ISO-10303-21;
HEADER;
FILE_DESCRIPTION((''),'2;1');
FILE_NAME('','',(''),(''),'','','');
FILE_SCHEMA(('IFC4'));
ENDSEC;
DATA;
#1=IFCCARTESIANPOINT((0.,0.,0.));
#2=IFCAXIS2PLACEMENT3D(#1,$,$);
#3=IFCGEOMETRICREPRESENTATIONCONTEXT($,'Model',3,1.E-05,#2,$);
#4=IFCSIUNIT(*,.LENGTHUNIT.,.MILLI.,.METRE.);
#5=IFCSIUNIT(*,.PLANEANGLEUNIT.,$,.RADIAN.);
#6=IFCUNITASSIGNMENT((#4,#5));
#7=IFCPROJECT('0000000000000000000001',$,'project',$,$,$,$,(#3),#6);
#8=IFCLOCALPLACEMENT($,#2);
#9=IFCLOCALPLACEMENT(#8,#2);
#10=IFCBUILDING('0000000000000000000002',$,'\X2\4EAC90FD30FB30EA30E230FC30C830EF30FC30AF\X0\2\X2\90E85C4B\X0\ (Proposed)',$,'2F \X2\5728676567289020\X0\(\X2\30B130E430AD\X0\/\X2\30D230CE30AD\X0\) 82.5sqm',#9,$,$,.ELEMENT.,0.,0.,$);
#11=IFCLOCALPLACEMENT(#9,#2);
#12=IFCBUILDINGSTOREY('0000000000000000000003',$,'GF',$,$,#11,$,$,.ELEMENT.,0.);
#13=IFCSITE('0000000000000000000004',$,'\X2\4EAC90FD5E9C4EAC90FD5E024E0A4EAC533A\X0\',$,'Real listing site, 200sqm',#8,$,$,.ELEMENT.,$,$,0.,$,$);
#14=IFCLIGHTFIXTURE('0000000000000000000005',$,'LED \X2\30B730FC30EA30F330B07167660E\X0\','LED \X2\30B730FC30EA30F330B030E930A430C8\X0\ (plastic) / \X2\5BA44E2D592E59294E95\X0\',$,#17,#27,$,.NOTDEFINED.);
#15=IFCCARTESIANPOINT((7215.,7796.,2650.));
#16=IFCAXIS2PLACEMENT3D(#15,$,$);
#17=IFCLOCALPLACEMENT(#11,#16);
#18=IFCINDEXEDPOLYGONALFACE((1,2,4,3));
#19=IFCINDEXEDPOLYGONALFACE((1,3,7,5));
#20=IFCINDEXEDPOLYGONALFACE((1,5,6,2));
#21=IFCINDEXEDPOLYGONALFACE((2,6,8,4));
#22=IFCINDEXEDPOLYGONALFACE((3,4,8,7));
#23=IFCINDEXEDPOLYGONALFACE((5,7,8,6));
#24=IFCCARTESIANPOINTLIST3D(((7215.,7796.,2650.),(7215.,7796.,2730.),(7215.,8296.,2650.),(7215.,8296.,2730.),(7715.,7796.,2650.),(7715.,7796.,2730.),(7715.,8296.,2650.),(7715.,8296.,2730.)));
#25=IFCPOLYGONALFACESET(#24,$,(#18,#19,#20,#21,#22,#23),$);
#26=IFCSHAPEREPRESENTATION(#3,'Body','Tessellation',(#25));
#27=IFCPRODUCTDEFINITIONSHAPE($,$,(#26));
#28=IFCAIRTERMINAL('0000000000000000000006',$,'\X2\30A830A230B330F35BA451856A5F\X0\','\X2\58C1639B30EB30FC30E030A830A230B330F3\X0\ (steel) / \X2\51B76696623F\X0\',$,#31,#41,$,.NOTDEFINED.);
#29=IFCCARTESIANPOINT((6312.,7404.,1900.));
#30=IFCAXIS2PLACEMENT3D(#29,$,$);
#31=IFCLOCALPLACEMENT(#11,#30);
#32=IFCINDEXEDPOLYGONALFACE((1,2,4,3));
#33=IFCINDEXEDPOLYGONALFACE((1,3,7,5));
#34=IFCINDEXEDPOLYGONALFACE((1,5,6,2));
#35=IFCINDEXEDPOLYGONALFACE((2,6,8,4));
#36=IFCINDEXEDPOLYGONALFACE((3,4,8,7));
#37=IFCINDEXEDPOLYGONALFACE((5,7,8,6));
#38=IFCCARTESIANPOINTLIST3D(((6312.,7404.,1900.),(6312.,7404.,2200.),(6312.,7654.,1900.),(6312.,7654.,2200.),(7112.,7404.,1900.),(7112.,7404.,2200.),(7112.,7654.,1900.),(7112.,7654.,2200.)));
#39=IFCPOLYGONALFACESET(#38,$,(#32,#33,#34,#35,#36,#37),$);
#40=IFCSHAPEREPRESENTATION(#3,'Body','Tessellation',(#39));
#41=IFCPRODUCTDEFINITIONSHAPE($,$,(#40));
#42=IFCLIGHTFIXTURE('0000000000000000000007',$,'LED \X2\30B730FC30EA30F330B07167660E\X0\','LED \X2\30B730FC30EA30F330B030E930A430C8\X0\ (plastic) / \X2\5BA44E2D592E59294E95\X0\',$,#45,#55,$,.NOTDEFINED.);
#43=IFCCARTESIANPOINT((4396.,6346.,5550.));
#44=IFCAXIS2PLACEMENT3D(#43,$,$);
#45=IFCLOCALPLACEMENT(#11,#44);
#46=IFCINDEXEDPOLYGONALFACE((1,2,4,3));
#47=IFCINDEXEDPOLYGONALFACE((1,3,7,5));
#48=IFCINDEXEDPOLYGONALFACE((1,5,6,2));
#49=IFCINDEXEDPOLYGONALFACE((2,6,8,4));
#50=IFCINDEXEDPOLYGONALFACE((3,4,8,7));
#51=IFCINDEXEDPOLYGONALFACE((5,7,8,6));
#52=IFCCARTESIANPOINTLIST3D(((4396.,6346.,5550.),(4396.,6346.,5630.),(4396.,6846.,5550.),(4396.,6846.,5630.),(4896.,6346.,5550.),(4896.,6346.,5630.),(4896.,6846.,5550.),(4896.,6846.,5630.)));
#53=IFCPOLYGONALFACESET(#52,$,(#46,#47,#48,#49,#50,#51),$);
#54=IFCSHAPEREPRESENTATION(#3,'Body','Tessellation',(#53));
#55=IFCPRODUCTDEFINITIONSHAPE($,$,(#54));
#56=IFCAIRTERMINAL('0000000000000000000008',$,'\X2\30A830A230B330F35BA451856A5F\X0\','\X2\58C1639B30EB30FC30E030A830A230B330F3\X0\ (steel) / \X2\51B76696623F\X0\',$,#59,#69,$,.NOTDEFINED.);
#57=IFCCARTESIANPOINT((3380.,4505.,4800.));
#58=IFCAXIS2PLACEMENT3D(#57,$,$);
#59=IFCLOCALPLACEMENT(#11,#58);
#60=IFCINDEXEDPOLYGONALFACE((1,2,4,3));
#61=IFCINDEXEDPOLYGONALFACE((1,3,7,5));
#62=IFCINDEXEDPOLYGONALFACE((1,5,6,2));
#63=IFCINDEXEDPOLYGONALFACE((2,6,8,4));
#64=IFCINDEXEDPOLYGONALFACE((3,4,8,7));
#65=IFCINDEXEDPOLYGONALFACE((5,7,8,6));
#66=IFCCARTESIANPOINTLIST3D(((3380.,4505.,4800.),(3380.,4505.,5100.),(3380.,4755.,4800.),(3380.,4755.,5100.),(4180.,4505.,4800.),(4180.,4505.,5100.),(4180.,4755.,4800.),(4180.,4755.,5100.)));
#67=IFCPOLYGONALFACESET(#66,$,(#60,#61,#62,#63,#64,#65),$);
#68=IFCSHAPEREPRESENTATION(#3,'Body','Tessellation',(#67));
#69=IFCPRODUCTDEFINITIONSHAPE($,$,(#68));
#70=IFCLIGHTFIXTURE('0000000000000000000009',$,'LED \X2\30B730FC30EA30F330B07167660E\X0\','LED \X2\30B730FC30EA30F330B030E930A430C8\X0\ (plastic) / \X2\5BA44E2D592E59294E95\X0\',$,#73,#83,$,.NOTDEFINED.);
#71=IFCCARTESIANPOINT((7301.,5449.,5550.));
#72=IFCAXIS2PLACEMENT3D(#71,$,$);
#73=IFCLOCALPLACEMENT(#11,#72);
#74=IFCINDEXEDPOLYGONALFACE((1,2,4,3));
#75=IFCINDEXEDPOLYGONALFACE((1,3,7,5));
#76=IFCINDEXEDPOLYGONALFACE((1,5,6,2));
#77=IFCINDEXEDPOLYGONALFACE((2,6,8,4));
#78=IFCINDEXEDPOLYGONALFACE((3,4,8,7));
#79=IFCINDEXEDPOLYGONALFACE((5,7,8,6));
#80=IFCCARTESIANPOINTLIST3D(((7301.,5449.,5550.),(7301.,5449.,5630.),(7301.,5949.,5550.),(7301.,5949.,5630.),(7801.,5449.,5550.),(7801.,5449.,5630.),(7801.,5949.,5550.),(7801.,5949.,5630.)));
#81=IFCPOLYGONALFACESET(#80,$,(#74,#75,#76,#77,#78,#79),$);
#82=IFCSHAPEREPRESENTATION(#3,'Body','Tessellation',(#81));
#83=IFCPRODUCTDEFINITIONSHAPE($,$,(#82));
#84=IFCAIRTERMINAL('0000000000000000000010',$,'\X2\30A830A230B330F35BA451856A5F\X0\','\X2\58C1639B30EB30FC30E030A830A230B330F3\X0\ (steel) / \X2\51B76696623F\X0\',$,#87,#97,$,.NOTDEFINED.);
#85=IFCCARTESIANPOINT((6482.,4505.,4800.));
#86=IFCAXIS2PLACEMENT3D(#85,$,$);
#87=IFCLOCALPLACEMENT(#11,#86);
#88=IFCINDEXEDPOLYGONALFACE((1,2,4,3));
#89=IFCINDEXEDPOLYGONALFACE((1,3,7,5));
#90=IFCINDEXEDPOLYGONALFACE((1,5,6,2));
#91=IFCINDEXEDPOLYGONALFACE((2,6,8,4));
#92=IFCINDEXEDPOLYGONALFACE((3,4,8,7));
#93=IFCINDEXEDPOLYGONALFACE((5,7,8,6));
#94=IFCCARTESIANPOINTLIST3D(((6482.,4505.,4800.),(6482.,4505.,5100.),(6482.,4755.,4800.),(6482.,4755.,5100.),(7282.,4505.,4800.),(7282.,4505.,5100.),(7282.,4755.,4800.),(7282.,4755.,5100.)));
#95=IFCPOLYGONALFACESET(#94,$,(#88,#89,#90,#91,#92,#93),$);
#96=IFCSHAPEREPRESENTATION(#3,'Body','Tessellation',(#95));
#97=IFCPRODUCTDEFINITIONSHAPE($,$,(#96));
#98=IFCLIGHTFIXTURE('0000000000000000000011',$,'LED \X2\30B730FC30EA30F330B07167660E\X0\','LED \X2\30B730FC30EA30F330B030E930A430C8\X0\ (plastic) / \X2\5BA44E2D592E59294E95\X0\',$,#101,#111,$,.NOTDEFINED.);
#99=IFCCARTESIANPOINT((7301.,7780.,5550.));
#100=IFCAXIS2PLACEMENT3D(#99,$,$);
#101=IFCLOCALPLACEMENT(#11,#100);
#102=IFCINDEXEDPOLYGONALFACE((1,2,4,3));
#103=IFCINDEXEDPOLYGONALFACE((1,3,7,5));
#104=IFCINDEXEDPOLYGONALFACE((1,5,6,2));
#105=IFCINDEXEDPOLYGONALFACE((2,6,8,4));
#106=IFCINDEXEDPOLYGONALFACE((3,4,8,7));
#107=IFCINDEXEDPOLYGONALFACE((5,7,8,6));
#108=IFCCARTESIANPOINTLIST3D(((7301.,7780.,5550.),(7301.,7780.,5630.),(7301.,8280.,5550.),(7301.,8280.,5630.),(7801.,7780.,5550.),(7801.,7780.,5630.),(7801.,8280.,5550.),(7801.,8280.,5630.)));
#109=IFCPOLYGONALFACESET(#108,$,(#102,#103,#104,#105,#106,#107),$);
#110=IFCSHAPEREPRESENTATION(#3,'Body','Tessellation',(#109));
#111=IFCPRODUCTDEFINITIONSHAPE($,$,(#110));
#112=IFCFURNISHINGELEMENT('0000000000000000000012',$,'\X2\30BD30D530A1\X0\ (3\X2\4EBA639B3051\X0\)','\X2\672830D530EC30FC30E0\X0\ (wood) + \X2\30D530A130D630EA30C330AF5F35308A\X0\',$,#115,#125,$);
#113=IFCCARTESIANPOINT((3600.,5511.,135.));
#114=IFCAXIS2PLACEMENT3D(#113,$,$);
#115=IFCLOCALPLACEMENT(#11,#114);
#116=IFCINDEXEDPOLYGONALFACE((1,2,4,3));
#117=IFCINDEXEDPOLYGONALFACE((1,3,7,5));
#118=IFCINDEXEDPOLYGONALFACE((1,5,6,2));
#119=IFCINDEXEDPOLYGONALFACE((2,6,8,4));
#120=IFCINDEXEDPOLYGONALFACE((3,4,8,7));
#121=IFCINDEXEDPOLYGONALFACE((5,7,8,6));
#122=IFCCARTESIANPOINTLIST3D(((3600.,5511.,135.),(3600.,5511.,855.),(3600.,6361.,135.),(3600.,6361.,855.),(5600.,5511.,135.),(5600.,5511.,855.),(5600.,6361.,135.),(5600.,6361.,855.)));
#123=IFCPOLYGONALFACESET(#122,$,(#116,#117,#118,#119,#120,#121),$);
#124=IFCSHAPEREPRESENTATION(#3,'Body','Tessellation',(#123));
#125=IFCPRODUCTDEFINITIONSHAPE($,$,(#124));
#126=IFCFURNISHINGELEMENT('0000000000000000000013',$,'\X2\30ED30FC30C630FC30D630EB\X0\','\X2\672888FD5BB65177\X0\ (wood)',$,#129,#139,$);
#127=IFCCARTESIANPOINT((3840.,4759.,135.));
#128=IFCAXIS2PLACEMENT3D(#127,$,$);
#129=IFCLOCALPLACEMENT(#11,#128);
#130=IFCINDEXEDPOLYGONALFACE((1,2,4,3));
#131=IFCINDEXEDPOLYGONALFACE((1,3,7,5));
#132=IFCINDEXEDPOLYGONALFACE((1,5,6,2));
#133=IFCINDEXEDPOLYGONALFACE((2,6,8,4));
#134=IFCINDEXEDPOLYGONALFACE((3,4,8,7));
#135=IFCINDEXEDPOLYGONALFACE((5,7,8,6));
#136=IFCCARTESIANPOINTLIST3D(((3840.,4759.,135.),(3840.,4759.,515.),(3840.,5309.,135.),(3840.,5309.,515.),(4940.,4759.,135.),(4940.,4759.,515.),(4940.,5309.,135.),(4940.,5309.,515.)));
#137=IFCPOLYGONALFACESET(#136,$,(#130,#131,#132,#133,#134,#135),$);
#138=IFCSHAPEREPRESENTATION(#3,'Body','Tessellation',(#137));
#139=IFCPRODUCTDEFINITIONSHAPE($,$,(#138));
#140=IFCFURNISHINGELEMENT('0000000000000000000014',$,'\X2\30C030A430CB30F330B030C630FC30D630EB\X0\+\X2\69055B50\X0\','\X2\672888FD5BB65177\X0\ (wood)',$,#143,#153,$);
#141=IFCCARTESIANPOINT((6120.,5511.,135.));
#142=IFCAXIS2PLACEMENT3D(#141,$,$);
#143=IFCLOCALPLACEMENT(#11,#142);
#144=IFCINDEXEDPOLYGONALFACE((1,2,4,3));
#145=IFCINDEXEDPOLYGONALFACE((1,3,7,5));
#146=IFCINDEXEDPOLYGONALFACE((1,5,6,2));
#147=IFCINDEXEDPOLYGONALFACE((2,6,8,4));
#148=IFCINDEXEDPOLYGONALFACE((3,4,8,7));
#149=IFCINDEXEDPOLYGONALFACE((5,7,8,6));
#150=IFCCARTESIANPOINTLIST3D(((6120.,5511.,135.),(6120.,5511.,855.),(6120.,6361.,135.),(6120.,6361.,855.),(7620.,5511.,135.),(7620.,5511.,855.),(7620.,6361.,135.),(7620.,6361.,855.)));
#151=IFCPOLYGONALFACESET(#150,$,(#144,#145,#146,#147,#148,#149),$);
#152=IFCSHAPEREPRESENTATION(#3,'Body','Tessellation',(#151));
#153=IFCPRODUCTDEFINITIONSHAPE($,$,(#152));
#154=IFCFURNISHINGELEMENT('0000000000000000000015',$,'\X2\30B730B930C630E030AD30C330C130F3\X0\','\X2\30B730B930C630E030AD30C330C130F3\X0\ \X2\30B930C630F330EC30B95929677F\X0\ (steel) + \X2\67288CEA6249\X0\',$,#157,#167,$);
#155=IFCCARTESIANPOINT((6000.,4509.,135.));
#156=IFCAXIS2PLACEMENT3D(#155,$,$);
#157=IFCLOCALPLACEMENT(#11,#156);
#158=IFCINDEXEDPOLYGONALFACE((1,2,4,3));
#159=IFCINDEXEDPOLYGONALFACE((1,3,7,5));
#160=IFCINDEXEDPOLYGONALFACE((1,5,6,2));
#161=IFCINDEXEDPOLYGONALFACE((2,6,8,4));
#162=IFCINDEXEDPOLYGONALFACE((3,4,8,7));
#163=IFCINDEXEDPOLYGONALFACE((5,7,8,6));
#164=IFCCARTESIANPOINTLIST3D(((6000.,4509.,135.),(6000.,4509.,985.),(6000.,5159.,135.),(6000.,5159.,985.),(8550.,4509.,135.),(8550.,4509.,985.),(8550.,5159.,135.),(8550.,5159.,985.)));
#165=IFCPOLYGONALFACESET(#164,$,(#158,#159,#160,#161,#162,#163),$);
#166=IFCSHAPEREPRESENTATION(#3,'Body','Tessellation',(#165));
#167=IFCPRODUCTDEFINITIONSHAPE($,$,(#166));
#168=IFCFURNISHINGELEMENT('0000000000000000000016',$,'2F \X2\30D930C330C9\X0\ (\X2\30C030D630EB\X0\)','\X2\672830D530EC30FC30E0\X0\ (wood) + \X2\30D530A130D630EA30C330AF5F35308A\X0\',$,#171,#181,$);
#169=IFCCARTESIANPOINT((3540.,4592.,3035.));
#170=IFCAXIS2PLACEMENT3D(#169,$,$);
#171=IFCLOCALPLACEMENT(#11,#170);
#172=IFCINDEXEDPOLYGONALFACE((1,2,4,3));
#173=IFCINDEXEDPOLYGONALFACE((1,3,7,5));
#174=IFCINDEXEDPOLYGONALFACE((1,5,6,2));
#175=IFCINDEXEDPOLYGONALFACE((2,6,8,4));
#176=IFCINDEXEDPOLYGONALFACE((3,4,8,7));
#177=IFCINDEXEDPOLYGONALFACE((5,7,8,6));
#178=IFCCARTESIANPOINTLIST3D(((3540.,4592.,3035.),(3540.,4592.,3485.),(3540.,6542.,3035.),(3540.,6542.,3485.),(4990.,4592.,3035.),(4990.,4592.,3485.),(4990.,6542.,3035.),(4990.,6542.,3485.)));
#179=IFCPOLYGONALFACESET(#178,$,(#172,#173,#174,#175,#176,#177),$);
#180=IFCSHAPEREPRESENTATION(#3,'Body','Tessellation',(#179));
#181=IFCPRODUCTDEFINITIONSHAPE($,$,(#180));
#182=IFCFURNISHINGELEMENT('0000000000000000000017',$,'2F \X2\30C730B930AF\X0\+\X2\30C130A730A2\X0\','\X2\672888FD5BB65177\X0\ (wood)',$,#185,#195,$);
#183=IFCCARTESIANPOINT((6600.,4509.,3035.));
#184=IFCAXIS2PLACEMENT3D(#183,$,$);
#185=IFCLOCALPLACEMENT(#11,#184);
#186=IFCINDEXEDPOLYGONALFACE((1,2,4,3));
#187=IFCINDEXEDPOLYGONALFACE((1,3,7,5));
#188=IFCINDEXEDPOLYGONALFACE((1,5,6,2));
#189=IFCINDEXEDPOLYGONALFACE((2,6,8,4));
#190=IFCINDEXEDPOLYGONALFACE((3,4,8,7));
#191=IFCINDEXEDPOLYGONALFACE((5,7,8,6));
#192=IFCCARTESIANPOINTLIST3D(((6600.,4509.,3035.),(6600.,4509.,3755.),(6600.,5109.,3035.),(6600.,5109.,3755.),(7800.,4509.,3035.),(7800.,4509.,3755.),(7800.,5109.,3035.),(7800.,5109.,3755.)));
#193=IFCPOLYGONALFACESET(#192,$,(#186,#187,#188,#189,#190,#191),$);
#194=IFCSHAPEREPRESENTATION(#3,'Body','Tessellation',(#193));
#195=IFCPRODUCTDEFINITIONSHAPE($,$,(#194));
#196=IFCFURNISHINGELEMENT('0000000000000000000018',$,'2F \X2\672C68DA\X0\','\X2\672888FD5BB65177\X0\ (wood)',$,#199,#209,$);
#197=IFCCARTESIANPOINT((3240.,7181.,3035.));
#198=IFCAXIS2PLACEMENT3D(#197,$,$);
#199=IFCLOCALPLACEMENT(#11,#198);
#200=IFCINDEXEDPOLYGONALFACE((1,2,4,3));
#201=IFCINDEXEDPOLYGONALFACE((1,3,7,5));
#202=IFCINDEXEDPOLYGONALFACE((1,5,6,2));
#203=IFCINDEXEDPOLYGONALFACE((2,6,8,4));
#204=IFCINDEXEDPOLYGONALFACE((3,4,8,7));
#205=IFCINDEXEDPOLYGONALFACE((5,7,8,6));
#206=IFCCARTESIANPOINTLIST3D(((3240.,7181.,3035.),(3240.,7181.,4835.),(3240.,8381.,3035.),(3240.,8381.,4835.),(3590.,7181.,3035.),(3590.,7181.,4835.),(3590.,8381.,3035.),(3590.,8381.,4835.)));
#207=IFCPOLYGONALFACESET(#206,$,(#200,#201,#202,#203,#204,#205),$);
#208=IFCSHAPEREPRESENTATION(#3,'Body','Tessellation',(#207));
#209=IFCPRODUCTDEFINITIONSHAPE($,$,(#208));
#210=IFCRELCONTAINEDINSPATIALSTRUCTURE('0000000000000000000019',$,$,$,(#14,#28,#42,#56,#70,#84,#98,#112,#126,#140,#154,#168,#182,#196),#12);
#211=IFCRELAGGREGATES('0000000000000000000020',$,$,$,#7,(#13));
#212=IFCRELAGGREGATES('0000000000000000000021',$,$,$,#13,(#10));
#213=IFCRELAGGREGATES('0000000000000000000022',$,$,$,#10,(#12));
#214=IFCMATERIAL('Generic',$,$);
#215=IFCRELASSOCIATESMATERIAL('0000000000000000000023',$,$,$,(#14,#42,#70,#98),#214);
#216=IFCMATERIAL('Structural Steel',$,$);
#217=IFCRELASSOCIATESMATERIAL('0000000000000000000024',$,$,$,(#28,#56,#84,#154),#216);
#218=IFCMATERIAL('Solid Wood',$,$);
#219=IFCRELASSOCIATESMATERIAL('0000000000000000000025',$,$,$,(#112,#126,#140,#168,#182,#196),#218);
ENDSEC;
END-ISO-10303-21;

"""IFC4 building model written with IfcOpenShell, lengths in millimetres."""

from ifc_helpers import new_model, si_unit, frame, frame_2d, origin, place, context, project, spatial, rectangle, extrude, material, element, save


model = new_model("IFC4")

# Units and contexts
model_context = context("Model", 3, precision=1e-05, world=origin())
ifc_project = project(units=[si_unit("LENGTHUNIT", "METRE", prefix="MILLI"), si_unit("PLANEANGLEUNIT", "RADIAN")], contexts=[model_context])

# Site, building, storey
site_placement = place(None, origin())
site = spatial("IfcSite", under=ifc_project, at=site_placement, Name="京都府京都市上京区", ObjectType="Real listing site, 200sqm", CompositionType="ELEMENT", RefElevation=0.0)
building_placement = place(site_placement, origin())
building = spatial("IfcBuilding", under=site, at=building_placement, Name="京都・リモートワーク2部屋 (Proposed)", ObjectType="2F 在来木造(ケヤキ/ヒノキ) 82.5sqm", CompositionType="ELEMENT", ElevationOfRefHeight=0.0, ElevationOfTerrain=0.0)
storey_placement = place(building_placement, origin())
storey = spatial("IfcBuildingStorey", under=building, at=storey_placement, Name="GF", CompositionType="ELEMENT", Elevation=0.0)

# Shared definitions
ifc_material_1 = material(Name="Solid Wood")

# Shared definitions
ifc_material_2 = material(Name="Structural Steel")

# Shared definitions
ifc_material_3 = material(Name="Generic")

# Light fixture
light_fixture_1_placement = place(storey_placement, frame((7215.0, 7796.0, 2650.0)))
element("IfcLightFixture", 1, at=light_fixture_1_placement, inside=storey, material=ifc_material_3, Name="LED シーリング照明", Description="LED シーリングライト (plastic) / 室中央天井", PredefinedType="NOTDEFINED", context=model_context, shape_type="SweptSolid", body=[
    extrude(rectangle(XDim=500.0, YDim=500.0, at=frame_2d((250.0, 250.0))), frame((7215.0, 7796.0, 2650.0)), (0.0, 0.0, 1.0), 80.0),
])

# Air terminal
air_terminal_1_placement = place(storey_placement, frame((6312.0, 7404.0, 1900.0)))
element("IfcAirTerminal", 2, at=air_terminal_1_placement, inside=storey, material=ifc_material_2, Name="エアコン室内機", Description="壁掛ルームエアコン (steel) / 冷暖房", PredefinedType="NOTDEFINED", context=model_context, shape_type="SweptSolid", body=[
    extrude(rectangle(XDim=800.0, YDim=250.0, at=frame_2d((400.0, 125.0))), frame((6312.0, 7404.0, 1900.0)), (0.0, 0.0, 1.0), 300.0),
])

# Light fixture
light_fixture_2_placement = place(storey_placement, frame((4396.0, 6346.0, 5550.0)))
element("IfcLightFixture", 3, at=light_fixture_2_placement, inside=storey, material=ifc_material_3, Name="LED シーリング照明", Description="LED シーリングライト (plastic) / 室中央天井", PredefinedType="NOTDEFINED", context=model_context, shape_type="SweptSolid", body=[
    extrude(rectangle(XDim=500.0, YDim=500.0, at=frame_2d((250.0, 250.0))), frame((4396.0, 6346.0, 5550.0)), (0.0, 0.0, 1.0), 80.0),
])

# Air terminal
air_terminal_2_placement = place(storey_placement, frame((3380.0, 4505.0, 4800.0)))
element("IfcAirTerminal", 4, at=air_terminal_2_placement, inside=storey, material=ifc_material_2, Name="エアコン室内機", Description="壁掛ルームエアコン (steel) / 冷暖房", PredefinedType="NOTDEFINED", context=model_context, shape_type="SweptSolid", body=[
    extrude(rectangle(XDim=800.0, YDim=250.0, at=frame_2d((400.0, 125.0))), frame((3380.0, 4505.0, 4800.0)), (0.0, 0.0, 1.0), 300.0),
])

# Light fixture
light_fixture_3_placement = place(storey_placement, frame((7301.0, 5449.0, 5550.0)))
element("IfcLightFixture", 5, at=light_fixture_3_placement, inside=storey, material=ifc_material_3, Name="LED シーリング照明", Description="LED シーリングライト (plastic) / 室中央天井", PredefinedType="NOTDEFINED", context=model_context, shape_type="SweptSolid", body=[
    extrude(rectangle(XDim=500.0, YDim=500.0, at=frame_2d((250.0, 250.0))), frame((7301.0, 5449.0, 5550.0)), (0.0, 0.0, 1.0), 80.0),
])

# Air terminal
air_terminal_3_placement = place(storey_placement, frame((6482.0, 4505.0, 4800.0)))
element("IfcAirTerminal", 6, at=air_terminal_3_placement, inside=storey, material=ifc_material_2, Name="エアコン室内機", Description="壁掛ルームエアコン (steel) / 冷暖房", PredefinedType="NOTDEFINED", context=model_context, shape_type="SweptSolid", body=[
    extrude(rectangle(XDim=800.0, YDim=250.0, at=frame_2d((400.0, 125.0))), frame((6482.0, 4505.0, 4800.0)), (0.0, 0.0, 1.0), 300.0),
])

# Light fixture
light_fixture_4_placement = place(storey_placement, frame((7301.0, 7780.0, 5550.0)))
element("IfcLightFixture", 7, at=light_fixture_4_placement, inside=storey, material=ifc_material_3, Name="LED シーリング照明", Description="LED シーリングライト (plastic) / 室中央天井", PredefinedType="NOTDEFINED", context=model_context, shape_type="SweptSolid", body=[
    extrude(rectangle(XDim=500.0, YDim=500.0, at=frame_2d((250.0, 250.0))), frame((7301.0, 7780.0, 5550.0)), (0.0, 0.0, 1.0), 80.0),
])

# Furnishing elements
furnishing_1_placement = place(storey_placement, frame((3600.0, 5511.0, 135.0)))
element("IfcFurnishingElement", 8, at=furnishing_1_placement, inside=storey, material=ifc_material_1, Name="ソファ (3人掛け)", Description="木フレーム (wood) + ファブリック張り", context=model_context, shape_type="SweptSolid", body=[
    extrude(rectangle(XDim=2000.0, YDim=850.0, at=frame_2d((1000.0, 425.0))), frame((3600.0, 5511.0, 135.0)), (0.0, 0.0, 1.0), 720.0),
])
furnishing_2_placement = place(storey_placement, frame((3840.0, 4759.0, 135.0)))
element("IfcFurnishingElement", 9, at=furnishing_2_placement, inside=storey, material=ifc_material_1, Name="ローテーブル", Description="木製家具 (wood)", context=model_context, shape_type="SweptSolid", body=[
    extrude(rectangle(XDim=1100.0, YDim=550.0, at=frame_2d((550.0, 275.0))), frame((3840.0, 4759.0, 135.0)), (0.0, 0.0, 1.0), 380.0),
])
furnishing_3_placement = place(storey_placement, frame((6120.0, 5511.0, 135.0)))
element("IfcFurnishingElement", 10, at=furnishing_3_placement, inside=storey, material=ifc_material_1, Name="ダイニングテーブル+椅子", Description="木製家具 (wood)", context=model_context, shape_type="SweptSolid", body=[
    extrude(rectangle(XDim=1500.0, YDim=850.0, at=frame_2d((750.0, 425.0))), frame((6120.0, 5511.0, 135.0)), (0.0, 0.0, 1.0), 720.0),
])
furnishing_4_placement = place(storey_placement, frame((6000.0, 4509.0, 135.0)))
element("IfcFurnishingElement", 11, at=furnishing_4_placement, inside=storey, material=ifc_material_2, Name="システムキッチン", Description="システムキッチン ステンレス天板 (steel) + 木質扉", context=model_context, shape_type="SweptSolid", body=[
    extrude(rectangle(XDim=2550.0, YDim=650.0, at=frame_2d((1275.0, 325.0))), frame((6000.0, 4509.0, 135.0)), (0.0, 0.0, 1.0), 850.0),
])
furnishing_5_placement = place(storey_placement, frame((3540.0, 4592.0, 3035.0)))
element("IfcFurnishingElement", 12, at=furnishing_5_placement, inside=storey, material=ifc_material_1, Name="2F ベッド (ダブル)", Description="木フレーム (wood) + ファブリック張り", context=model_context, shape_type="SweptSolid", body=[
    extrude(rectangle(XDim=1450.0, YDim=1950.0, at=frame_2d((725.0, 975.0))), frame((3540.0, 4592.0, 3035.0)), (0.0, 0.0, 1.0), 450.0),
])
furnishing_6_placement = place(storey_placement, frame((6600.0, 4509.0, 3035.0)))
element("IfcFurnishingElement", 13, at=furnishing_6_placement, inside=storey, material=ifc_material_1, Name="2F デスク+チェア", Description="木製家具 (wood)", context=model_context, shape_type="SweptSolid", body=[
    extrude(rectangle(XDim=1200.0, YDim=600.0, at=frame_2d((600.0, 300.0))), frame((6600.0, 4509.0, 3035.0)), (0.0, 0.0, 1.0), 720.0),
])
furnishing_7_placement = place(storey_placement, frame((3240.0, 7181.0, 3035.0)))
element("IfcFurnishingElement", 14, at=furnishing_7_placement, inside=storey, material=ifc_material_1, Name="2F 本棚", Description="木製家具 (wood)", context=model_context, shape_type="SweptSolid", body=[
    extrude(rectangle(XDim=350.0, YDim=1200.0, at=frame_2d((175.0, 600.0))), frame((3240.0, 7181.0, 3035.0)), (0.0, 0.0, 1.0), 1800.0),
])

save(model, "model.ifc")
